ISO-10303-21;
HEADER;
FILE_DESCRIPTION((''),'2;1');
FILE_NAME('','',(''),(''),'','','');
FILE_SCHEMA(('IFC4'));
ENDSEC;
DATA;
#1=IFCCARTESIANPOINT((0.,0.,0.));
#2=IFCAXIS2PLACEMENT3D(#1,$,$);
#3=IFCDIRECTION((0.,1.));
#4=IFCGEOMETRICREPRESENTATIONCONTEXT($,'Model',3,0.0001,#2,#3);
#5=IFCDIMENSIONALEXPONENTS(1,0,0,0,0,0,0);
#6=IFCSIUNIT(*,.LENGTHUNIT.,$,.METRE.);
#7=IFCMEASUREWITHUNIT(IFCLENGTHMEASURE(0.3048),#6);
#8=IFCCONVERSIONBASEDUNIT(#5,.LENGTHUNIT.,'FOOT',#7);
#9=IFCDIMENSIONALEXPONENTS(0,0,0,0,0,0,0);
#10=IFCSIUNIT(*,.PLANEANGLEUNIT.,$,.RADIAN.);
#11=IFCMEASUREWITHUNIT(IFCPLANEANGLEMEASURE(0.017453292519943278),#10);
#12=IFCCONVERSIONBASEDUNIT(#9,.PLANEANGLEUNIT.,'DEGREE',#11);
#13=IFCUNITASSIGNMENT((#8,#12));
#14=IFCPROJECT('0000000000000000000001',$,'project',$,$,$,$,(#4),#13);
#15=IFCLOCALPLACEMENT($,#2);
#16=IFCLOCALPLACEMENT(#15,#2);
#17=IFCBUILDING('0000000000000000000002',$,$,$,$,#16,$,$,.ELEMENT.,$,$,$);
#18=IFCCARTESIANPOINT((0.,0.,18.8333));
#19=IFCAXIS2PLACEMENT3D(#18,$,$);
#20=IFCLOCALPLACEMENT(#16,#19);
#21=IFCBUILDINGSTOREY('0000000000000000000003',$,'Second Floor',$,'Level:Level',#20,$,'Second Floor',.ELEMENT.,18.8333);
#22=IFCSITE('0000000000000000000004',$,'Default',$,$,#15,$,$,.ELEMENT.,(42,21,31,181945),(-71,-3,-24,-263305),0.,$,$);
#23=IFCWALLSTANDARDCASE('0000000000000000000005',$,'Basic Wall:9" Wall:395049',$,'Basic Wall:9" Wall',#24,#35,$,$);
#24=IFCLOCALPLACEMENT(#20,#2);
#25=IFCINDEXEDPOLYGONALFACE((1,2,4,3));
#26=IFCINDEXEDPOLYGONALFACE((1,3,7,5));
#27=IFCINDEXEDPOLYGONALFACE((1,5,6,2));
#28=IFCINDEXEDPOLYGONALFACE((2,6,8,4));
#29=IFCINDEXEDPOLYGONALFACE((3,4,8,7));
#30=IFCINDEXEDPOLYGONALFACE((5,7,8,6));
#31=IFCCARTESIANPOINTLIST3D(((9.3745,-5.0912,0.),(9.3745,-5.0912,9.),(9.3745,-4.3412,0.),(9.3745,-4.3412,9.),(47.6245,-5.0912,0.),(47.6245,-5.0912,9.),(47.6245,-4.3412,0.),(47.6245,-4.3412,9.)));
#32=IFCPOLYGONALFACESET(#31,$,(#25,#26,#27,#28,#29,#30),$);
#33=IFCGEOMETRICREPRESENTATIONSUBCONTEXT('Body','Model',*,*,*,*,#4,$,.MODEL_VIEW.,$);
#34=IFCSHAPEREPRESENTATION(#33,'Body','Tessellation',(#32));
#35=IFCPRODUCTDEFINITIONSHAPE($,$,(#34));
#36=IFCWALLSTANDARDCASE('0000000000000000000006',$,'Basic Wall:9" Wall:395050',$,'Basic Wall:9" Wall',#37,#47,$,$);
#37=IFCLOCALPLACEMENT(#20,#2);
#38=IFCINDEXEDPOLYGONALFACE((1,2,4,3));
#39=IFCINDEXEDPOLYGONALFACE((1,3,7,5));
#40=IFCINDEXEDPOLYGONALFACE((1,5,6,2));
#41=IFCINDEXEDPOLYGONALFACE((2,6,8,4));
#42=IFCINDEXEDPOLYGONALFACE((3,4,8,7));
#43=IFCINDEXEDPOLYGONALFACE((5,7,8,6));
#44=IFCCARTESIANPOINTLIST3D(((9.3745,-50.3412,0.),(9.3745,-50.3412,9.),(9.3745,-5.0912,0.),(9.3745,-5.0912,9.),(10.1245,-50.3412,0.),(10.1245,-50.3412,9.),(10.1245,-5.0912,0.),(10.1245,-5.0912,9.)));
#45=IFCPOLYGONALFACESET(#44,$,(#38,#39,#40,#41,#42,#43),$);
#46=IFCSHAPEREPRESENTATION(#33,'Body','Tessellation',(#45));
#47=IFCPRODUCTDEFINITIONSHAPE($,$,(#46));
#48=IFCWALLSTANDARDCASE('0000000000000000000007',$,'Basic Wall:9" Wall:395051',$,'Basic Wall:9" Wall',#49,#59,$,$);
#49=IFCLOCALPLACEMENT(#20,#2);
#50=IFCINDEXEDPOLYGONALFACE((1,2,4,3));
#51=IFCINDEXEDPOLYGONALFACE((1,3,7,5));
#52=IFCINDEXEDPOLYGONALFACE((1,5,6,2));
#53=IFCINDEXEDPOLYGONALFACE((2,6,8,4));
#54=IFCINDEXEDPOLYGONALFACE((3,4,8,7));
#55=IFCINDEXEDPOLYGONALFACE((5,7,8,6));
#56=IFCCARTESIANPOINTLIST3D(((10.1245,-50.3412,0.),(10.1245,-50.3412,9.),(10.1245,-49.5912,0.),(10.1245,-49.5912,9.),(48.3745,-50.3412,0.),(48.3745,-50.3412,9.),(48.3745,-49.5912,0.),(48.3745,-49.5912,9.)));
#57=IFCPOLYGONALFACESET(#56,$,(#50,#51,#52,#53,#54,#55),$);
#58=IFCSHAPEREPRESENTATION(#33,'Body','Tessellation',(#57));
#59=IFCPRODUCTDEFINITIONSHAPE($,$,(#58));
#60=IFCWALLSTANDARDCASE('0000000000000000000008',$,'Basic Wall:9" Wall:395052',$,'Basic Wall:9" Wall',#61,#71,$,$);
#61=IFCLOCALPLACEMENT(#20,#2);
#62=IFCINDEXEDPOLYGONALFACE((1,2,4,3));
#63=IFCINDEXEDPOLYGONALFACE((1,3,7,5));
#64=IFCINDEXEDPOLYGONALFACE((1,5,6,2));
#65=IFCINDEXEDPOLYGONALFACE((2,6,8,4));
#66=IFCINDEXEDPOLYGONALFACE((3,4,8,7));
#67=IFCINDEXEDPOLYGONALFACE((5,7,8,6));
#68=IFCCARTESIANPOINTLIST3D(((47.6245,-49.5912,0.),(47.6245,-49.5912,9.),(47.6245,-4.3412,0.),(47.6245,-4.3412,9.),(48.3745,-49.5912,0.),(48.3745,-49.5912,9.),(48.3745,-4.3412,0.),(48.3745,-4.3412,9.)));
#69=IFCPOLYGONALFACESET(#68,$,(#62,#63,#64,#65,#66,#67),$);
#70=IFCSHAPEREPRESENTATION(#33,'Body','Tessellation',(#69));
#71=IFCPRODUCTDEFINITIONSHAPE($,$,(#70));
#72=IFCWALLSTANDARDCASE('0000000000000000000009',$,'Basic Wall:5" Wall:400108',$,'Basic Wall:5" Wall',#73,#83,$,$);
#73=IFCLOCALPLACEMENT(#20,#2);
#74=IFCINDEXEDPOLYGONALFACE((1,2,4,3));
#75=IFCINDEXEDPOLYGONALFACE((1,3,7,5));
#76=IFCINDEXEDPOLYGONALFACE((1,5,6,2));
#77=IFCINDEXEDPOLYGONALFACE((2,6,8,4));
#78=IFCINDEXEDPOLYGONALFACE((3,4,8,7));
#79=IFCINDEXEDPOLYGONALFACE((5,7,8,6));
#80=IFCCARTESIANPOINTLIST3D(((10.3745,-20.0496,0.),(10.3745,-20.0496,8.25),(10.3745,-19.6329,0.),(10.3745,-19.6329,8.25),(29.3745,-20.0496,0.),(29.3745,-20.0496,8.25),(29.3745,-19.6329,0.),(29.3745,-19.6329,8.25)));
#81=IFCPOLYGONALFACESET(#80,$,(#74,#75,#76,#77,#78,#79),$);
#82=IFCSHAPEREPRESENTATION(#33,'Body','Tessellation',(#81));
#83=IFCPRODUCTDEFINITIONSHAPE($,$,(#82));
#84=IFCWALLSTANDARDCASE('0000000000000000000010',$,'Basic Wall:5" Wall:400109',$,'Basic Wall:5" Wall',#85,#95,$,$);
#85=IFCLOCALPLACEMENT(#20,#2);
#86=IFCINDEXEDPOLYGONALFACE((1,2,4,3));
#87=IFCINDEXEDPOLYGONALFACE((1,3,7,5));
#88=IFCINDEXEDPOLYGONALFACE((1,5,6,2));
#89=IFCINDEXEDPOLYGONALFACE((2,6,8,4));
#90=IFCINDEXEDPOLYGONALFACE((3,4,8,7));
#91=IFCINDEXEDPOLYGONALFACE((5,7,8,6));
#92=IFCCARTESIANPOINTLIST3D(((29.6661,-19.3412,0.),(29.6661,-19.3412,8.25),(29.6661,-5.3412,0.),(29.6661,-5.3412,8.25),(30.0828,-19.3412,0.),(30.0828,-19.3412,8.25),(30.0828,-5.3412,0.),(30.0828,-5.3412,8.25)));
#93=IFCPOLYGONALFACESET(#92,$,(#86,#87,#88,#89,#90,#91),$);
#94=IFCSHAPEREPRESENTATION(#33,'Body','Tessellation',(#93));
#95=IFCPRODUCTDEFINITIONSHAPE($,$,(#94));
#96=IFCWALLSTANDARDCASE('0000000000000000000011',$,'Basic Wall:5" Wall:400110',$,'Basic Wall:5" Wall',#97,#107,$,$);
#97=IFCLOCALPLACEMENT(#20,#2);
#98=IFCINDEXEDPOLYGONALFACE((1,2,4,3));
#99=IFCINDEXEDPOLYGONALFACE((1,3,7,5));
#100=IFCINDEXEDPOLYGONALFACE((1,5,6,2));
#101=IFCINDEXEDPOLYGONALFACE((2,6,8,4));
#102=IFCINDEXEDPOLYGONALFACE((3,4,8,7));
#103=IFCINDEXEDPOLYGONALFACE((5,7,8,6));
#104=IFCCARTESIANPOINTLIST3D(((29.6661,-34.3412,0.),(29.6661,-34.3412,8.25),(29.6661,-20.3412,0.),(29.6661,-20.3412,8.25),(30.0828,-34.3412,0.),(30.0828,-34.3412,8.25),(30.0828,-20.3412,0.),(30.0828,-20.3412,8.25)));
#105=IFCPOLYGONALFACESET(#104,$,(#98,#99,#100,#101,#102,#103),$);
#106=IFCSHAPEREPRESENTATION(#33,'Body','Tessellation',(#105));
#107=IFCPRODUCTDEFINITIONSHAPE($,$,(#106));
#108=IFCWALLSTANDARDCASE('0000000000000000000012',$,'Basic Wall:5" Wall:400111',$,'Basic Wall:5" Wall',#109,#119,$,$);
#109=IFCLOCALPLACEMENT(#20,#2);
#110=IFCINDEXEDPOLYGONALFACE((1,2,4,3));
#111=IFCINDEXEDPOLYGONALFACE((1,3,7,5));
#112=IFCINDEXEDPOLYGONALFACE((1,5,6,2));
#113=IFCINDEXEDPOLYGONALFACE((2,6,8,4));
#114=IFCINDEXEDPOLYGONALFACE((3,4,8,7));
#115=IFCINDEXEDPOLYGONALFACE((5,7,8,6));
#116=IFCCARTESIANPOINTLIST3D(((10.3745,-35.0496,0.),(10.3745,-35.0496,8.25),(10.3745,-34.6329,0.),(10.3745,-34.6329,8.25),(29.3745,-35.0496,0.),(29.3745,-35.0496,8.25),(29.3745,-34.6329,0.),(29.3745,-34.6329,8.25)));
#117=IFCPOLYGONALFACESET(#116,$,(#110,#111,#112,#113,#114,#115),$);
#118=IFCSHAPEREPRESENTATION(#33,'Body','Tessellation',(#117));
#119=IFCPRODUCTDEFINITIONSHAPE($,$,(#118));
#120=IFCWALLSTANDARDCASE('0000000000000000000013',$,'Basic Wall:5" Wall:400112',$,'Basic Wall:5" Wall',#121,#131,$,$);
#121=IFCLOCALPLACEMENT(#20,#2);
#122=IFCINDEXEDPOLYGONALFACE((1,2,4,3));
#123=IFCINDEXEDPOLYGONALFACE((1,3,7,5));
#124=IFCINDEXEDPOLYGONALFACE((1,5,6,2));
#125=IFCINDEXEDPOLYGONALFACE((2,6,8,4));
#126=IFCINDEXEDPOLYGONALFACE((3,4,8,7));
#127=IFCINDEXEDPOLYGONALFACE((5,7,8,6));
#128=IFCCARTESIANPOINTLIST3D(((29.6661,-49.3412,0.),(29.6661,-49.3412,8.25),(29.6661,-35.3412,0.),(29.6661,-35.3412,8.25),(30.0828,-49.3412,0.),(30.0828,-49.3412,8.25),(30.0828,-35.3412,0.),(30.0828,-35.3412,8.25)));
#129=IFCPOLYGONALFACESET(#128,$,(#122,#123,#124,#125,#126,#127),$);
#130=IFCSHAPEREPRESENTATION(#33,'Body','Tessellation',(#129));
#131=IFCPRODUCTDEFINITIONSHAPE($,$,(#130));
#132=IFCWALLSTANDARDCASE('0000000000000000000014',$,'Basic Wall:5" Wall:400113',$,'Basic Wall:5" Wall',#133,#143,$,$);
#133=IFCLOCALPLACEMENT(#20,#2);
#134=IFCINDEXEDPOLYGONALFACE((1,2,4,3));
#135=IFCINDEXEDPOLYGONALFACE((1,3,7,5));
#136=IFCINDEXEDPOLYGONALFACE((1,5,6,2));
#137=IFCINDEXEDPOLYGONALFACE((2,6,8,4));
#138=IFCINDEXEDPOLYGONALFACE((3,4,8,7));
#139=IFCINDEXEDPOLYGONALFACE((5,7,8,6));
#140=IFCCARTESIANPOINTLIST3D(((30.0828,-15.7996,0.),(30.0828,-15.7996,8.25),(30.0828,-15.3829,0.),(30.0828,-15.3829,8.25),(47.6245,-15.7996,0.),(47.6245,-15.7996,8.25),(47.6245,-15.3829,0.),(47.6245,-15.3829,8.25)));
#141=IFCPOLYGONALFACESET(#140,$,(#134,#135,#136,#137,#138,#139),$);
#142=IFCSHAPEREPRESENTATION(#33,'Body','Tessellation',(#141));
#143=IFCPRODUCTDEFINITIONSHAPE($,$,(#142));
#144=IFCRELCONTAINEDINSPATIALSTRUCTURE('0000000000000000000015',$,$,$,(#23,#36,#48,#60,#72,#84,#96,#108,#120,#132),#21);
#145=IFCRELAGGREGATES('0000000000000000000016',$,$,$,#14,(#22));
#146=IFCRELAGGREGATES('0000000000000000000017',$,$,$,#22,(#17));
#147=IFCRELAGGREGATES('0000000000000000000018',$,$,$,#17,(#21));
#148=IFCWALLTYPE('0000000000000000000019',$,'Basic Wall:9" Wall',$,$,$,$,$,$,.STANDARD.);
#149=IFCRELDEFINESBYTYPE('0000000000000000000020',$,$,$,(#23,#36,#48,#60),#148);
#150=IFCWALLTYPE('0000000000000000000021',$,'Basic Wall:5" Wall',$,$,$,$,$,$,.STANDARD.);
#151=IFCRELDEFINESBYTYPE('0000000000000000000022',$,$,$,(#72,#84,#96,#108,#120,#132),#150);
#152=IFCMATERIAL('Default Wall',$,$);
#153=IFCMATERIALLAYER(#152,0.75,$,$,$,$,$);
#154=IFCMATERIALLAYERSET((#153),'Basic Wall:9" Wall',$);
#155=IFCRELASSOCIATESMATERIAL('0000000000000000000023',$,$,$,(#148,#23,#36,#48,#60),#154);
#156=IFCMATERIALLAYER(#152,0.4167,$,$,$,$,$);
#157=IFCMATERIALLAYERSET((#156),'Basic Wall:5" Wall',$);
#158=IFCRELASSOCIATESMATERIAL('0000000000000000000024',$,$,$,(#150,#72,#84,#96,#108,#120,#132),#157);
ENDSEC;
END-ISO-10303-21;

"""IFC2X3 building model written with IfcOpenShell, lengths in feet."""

from ifc_helpers import new_model, entity, si_unit, converted_unit, direction, frame, frame_2d, origin, place, context, subcontext, project, spatial, rectangle, extrude, material, layer, layer_set, layer_usage, type_object, element, save


model = new_model("IFC2X3")

# Units and contexts
model_context = context("Model", 3, precision=0.0001, world=origin(), true_north=direction((0.0, 1.0)))
body_context = subcontext(model_context, "Body", "Model", "MODEL_VIEW")
ifc_project = project(units=[converted_unit("LENGTHUNIT", "FOOT", entity("IfcLengthMeasure", 0.3048), si_unit("LENGTHUNIT", "METRE"), dimensions=[1, 0, 0, 0, 0, 0, 0]), converted_unit("PLANEANGLEUNIT", "DEGREE", entity("IfcPlaneAngleMeasure", 0.017453292519943278), si_unit("PLANEANGLEUNIT", "RADIAN"), dimensions=[0, 0, 0, 0, 0, 0, 0])], contexts=[model_context])

# Site, building, storey
site_placement = place(None, origin())
site = spatial("IfcSite", under=ifc_project, at=site_placement, Name="Default", CompositionType="ELEMENT", RefLatitude=(42, 21, 31, 181945), RefLongitude=(-71, -3, -24, -263305), RefElevation=0.0)
building_placement = place(site_placement, origin())
building = spatial("IfcBuilding", under=site, at=building_placement, CompositionType="ELEMENT")
storey_placement = place(building_placement, frame((0.0, 0.0, 18.8333)))
storey = spatial("IfcBuildingStorey", under=building, at=storey_placement, Name="Second Floor", ObjectType="Level:Level", LongName="Second Floor", CompositionType="ELEMENT", Elevation=18.8333)

# Walls
ifc_material_1 = material(Name="Default Wall")
ifc_layer_1 = layer(ifc_material_1, 0.75)
ifc_layer_set_1 = layer_set([ifc_layer_1], Name="Basic Wall:9\" Wall")
ifc_layer_usage_1 = layer_usage(ifc_layer_set_1, "AXIS2", "NEGATIVE", 0.375)
wall_type_1 = type_object("IfcWallType", Name="Basic Wall:9\" Wall", PredefinedType="STANDARD", material=ifc_layer_set_1)
wall_1_placement = place(storey_placement, frame((9.3745, -4.7162, 0.0)))
element("IfcWallStandardCase", 1, at=wall_1_placement, inside=storey, type_object=wall_type_1, material=ifc_layer_usage_1, Name="Basic Wall:9\" Wall:395049", ObjectType="Basic Wall:9\" Wall", context=body_context, shape_type="SweptSolid", body=[
    extrude(rectangle(XDim=38.25, YDim=0.75, at=frame_2d((19.125, 0.0), x_axis=(-1.0, 0.0))), origin(), (0.0, 0.0, 1.0), 9.0),
])
wall_2_placement = place(storey_placement, frame((9.7495, -50.3412, 0.0), z_axis=(0.0, 0.0, 1.0), x_axis=(0.0, 1.0, 0.0)))
element("IfcWallStandardCase", 2, at=wall_2_placement, inside=storey, type_object=wall_type_1, material=ifc_layer_usage_1, Name="Basic Wall:9\" Wall:395050", ObjectType="Basic Wall:9\" Wall", context=body_context, shape_type="SweptSolid", body=[
    extrude(rectangle(XDim=45.25, YDim=0.75, at=frame_2d((22.625, 0.0), x_axis=(-1.0, 0.0))), origin(), (0.0, 0.0, 1.0), 9.0),
])
wall_3_placement = place(storey_placement, frame((48.3745, -49.9662, 0.0), z_axis=(0.0, 0.0, 1.0), x_axis=(-1.0, 0.0, 0.0)))
element("IfcWallStandardCase", 3, at=wall_3_placement, inside=storey, type_object=wall_type_1, material=ifc_layer_usage_1, Name="Basic Wall:9\" Wall:395051", ObjectType="Basic Wall:9\" Wall", context=body_context, shape_type="SweptSolid", body=[
    extrude(rectangle(XDim=38.25, YDim=0.75, at=frame_2d((19.125, 0.0), x_axis=(-1.0, 0.0))), origin(), (0.0, 0.0, 1.0), 9.0),
])
wall_4_placement = place(storey_placement, frame((47.9995, -4.3412, 0.0), z_axis=(0.0, 0.0, 1.0), x_axis=(0.0, -1.0, 0.0)))
element("IfcWallStandardCase", 4, at=wall_4_placement, inside=storey, type_object=wall_type_1, material=ifc_layer_usage_1, Name="Basic Wall:9\" Wall:395052", ObjectType="Basic Wall:9\" Wall", context=body_context, shape_type="SweptSolid", body=[
    extrude(rectangle(XDim=45.25, YDim=0.75, at=frame_2d((22.625, 0.0), x_axis=(-1.0, 0.0))), origin(), (0.0, 0.0, 1.0), 9.0),
])
ifc_layer_2 = layer(ifc_material_1, 0.4167)
ifc_layer_set_2 = layer_set([ifc_layer_2], Name="Basic Wall:5\" Wall")
ifc_layer_usage_2 = layer_usage(ifc_layer_set_2, "AXIS2", "NEGATIVE", 0.2083)
wall_type_2 = type_object("IfcWallType", Name="Basic Wall:5\" Wall", PredefinedType="STANDARD", material=ifc_layer_set_2)
wall_5_placement = place(storey_placement, frame((10.3745, -19.8412, 0.0)))
element("IfcWallStandardCase", 5, at=wall_5_placement, inside=storey, type_object=wall_type_2, material=ifc_layer_usage_2, Name="Basic Wall:5\" Wall:400108", ObjectType="Basic Wall:5\" Wall", context=body_context, shape_type="SweptSolid", body=[
    extrude(rectangle(XDim=19.0, YDim=0.4167, at=frame_2d((9.5, 0.0), x_axis=(-1.0, 0.0))), origin(), (0.0, 0.0, 1.0), 8.25),
])
wall_6_placement = place(storey_placement, frame((29.8745, -19.3412, 0.0), z_axis=(0.0, 0.0, 1.0), x_axis=(0.0, 1.0, 0.0)))
element("IfcWallStandardCase", 6, at=wall_6_placement, inside=storey, type_object=wall_type_2, material=ifc_layer_usage_2, Name="Basic Wall:5\" Wall:400109", ObjectType="Basic Wall:5\" Wall", context=body_context, shape_type="SweptSolid", body=[
    extrude(rectangle(XDim=14.0, YDim=0.4167, at=frame_2d((7.0, 0.0), x_axis=(-1.0, 0.0))), origin(), (0.0, 0.0, 1.0), 8.25),
])
wall_7_placement = place(storey_placement, frame((29.8745, -20.3412, 0.0), z_axis=(0.0, 0.0, 1.0), x_axis=(0.0, -1.0, 0.0)))
element("IfcWallStandardCase", 7, at=wall_7_placement, inside=storey, type_object=wall_type_2, material=ifc_layer_usage_2, Name="Basic Wall:5\" Wall:400110", ObjectType="Basic Wall:5\" Wall", context=body_context, shape_type="SweptSolid", body=[
    extrude(rectangle(XDim=14.0, YDim=0.4167, at=frame_2d((7.0, 0.0), x_axis=(-1.0, 0.0))), origin(), (0.0, 0.0, 1.0), 8.25),
])
wall_8_placement = place(storey_placement, frame((29.3745, -34.8412, 0.0), z_axis=(0.0, 0.0, 1.0), x_axis=(-1.0, 0.0, 0.0)))
element("IfcWallStandardCase", 8, at=wall_8_placement, inside=storey, type_object=wall_type_2, material=ifc_layer_usage_2, Name="Basic Wall:5\" Wall:400111", ObjectType="Basic Wall:5\" Wall", context=body_context, shape_type="SweptSolid", body=[
    extrude(rectangle(XDim=19.0, YDim=0.4167, at=frame_2d((9.5, 0.0), x_axis=(-1.0, 0.0))), origin(), (0.0, 0.0, 1.0), 8.25),
])
wall_9_placement = place(storey_placement, frame((29.8745, -35.3412, 0.0), z_axis=(0.0, 0.0, 1.0), x_axis=(0.0, -1.0, 0.0)))
element("IfcWallStandardCase", 9, at=wall_9_placement, inside=storey, type_object=wall_type_2, material=ifc_layer_usage_2, Name="Basic Wall:5\" Wall:400112", ObjectType="Basic Wall:5\" Wall", context=body_context, shape_type="SweptSolid", body=[
    extrude(rectangle(XDim=14.0, YDim=0.4167, at=frame_2d((7.0, 0.0), x_axis=(-1.0, 0.0))), origin(), (0.0, 0.0, 1.0), 8.25),
])
wall_10_placement = place(storey_placement, frame((30.0828, -15.5912, 0.0)))
element("IfcWallStandardCase", 10, at=wall_10_placement, inside=storey, type_object=wall_type_2, material=ifc_layer_usage_2, Name="Basic Wall:5\" Wall:400113", ObjectType="Basic Wall:5\" Wall", context=body_context, shape_type="SweptSolid", body=[
    extrude(rectangle(XDim=17.5417, YDim=0.4167, at=frame_2d((8.7708, 0.0), x_axis=(-1.0, 0.0))), origin(), (0.0, 0.0, 1.0), 8.25),
])

save(model, "model.ifc")
